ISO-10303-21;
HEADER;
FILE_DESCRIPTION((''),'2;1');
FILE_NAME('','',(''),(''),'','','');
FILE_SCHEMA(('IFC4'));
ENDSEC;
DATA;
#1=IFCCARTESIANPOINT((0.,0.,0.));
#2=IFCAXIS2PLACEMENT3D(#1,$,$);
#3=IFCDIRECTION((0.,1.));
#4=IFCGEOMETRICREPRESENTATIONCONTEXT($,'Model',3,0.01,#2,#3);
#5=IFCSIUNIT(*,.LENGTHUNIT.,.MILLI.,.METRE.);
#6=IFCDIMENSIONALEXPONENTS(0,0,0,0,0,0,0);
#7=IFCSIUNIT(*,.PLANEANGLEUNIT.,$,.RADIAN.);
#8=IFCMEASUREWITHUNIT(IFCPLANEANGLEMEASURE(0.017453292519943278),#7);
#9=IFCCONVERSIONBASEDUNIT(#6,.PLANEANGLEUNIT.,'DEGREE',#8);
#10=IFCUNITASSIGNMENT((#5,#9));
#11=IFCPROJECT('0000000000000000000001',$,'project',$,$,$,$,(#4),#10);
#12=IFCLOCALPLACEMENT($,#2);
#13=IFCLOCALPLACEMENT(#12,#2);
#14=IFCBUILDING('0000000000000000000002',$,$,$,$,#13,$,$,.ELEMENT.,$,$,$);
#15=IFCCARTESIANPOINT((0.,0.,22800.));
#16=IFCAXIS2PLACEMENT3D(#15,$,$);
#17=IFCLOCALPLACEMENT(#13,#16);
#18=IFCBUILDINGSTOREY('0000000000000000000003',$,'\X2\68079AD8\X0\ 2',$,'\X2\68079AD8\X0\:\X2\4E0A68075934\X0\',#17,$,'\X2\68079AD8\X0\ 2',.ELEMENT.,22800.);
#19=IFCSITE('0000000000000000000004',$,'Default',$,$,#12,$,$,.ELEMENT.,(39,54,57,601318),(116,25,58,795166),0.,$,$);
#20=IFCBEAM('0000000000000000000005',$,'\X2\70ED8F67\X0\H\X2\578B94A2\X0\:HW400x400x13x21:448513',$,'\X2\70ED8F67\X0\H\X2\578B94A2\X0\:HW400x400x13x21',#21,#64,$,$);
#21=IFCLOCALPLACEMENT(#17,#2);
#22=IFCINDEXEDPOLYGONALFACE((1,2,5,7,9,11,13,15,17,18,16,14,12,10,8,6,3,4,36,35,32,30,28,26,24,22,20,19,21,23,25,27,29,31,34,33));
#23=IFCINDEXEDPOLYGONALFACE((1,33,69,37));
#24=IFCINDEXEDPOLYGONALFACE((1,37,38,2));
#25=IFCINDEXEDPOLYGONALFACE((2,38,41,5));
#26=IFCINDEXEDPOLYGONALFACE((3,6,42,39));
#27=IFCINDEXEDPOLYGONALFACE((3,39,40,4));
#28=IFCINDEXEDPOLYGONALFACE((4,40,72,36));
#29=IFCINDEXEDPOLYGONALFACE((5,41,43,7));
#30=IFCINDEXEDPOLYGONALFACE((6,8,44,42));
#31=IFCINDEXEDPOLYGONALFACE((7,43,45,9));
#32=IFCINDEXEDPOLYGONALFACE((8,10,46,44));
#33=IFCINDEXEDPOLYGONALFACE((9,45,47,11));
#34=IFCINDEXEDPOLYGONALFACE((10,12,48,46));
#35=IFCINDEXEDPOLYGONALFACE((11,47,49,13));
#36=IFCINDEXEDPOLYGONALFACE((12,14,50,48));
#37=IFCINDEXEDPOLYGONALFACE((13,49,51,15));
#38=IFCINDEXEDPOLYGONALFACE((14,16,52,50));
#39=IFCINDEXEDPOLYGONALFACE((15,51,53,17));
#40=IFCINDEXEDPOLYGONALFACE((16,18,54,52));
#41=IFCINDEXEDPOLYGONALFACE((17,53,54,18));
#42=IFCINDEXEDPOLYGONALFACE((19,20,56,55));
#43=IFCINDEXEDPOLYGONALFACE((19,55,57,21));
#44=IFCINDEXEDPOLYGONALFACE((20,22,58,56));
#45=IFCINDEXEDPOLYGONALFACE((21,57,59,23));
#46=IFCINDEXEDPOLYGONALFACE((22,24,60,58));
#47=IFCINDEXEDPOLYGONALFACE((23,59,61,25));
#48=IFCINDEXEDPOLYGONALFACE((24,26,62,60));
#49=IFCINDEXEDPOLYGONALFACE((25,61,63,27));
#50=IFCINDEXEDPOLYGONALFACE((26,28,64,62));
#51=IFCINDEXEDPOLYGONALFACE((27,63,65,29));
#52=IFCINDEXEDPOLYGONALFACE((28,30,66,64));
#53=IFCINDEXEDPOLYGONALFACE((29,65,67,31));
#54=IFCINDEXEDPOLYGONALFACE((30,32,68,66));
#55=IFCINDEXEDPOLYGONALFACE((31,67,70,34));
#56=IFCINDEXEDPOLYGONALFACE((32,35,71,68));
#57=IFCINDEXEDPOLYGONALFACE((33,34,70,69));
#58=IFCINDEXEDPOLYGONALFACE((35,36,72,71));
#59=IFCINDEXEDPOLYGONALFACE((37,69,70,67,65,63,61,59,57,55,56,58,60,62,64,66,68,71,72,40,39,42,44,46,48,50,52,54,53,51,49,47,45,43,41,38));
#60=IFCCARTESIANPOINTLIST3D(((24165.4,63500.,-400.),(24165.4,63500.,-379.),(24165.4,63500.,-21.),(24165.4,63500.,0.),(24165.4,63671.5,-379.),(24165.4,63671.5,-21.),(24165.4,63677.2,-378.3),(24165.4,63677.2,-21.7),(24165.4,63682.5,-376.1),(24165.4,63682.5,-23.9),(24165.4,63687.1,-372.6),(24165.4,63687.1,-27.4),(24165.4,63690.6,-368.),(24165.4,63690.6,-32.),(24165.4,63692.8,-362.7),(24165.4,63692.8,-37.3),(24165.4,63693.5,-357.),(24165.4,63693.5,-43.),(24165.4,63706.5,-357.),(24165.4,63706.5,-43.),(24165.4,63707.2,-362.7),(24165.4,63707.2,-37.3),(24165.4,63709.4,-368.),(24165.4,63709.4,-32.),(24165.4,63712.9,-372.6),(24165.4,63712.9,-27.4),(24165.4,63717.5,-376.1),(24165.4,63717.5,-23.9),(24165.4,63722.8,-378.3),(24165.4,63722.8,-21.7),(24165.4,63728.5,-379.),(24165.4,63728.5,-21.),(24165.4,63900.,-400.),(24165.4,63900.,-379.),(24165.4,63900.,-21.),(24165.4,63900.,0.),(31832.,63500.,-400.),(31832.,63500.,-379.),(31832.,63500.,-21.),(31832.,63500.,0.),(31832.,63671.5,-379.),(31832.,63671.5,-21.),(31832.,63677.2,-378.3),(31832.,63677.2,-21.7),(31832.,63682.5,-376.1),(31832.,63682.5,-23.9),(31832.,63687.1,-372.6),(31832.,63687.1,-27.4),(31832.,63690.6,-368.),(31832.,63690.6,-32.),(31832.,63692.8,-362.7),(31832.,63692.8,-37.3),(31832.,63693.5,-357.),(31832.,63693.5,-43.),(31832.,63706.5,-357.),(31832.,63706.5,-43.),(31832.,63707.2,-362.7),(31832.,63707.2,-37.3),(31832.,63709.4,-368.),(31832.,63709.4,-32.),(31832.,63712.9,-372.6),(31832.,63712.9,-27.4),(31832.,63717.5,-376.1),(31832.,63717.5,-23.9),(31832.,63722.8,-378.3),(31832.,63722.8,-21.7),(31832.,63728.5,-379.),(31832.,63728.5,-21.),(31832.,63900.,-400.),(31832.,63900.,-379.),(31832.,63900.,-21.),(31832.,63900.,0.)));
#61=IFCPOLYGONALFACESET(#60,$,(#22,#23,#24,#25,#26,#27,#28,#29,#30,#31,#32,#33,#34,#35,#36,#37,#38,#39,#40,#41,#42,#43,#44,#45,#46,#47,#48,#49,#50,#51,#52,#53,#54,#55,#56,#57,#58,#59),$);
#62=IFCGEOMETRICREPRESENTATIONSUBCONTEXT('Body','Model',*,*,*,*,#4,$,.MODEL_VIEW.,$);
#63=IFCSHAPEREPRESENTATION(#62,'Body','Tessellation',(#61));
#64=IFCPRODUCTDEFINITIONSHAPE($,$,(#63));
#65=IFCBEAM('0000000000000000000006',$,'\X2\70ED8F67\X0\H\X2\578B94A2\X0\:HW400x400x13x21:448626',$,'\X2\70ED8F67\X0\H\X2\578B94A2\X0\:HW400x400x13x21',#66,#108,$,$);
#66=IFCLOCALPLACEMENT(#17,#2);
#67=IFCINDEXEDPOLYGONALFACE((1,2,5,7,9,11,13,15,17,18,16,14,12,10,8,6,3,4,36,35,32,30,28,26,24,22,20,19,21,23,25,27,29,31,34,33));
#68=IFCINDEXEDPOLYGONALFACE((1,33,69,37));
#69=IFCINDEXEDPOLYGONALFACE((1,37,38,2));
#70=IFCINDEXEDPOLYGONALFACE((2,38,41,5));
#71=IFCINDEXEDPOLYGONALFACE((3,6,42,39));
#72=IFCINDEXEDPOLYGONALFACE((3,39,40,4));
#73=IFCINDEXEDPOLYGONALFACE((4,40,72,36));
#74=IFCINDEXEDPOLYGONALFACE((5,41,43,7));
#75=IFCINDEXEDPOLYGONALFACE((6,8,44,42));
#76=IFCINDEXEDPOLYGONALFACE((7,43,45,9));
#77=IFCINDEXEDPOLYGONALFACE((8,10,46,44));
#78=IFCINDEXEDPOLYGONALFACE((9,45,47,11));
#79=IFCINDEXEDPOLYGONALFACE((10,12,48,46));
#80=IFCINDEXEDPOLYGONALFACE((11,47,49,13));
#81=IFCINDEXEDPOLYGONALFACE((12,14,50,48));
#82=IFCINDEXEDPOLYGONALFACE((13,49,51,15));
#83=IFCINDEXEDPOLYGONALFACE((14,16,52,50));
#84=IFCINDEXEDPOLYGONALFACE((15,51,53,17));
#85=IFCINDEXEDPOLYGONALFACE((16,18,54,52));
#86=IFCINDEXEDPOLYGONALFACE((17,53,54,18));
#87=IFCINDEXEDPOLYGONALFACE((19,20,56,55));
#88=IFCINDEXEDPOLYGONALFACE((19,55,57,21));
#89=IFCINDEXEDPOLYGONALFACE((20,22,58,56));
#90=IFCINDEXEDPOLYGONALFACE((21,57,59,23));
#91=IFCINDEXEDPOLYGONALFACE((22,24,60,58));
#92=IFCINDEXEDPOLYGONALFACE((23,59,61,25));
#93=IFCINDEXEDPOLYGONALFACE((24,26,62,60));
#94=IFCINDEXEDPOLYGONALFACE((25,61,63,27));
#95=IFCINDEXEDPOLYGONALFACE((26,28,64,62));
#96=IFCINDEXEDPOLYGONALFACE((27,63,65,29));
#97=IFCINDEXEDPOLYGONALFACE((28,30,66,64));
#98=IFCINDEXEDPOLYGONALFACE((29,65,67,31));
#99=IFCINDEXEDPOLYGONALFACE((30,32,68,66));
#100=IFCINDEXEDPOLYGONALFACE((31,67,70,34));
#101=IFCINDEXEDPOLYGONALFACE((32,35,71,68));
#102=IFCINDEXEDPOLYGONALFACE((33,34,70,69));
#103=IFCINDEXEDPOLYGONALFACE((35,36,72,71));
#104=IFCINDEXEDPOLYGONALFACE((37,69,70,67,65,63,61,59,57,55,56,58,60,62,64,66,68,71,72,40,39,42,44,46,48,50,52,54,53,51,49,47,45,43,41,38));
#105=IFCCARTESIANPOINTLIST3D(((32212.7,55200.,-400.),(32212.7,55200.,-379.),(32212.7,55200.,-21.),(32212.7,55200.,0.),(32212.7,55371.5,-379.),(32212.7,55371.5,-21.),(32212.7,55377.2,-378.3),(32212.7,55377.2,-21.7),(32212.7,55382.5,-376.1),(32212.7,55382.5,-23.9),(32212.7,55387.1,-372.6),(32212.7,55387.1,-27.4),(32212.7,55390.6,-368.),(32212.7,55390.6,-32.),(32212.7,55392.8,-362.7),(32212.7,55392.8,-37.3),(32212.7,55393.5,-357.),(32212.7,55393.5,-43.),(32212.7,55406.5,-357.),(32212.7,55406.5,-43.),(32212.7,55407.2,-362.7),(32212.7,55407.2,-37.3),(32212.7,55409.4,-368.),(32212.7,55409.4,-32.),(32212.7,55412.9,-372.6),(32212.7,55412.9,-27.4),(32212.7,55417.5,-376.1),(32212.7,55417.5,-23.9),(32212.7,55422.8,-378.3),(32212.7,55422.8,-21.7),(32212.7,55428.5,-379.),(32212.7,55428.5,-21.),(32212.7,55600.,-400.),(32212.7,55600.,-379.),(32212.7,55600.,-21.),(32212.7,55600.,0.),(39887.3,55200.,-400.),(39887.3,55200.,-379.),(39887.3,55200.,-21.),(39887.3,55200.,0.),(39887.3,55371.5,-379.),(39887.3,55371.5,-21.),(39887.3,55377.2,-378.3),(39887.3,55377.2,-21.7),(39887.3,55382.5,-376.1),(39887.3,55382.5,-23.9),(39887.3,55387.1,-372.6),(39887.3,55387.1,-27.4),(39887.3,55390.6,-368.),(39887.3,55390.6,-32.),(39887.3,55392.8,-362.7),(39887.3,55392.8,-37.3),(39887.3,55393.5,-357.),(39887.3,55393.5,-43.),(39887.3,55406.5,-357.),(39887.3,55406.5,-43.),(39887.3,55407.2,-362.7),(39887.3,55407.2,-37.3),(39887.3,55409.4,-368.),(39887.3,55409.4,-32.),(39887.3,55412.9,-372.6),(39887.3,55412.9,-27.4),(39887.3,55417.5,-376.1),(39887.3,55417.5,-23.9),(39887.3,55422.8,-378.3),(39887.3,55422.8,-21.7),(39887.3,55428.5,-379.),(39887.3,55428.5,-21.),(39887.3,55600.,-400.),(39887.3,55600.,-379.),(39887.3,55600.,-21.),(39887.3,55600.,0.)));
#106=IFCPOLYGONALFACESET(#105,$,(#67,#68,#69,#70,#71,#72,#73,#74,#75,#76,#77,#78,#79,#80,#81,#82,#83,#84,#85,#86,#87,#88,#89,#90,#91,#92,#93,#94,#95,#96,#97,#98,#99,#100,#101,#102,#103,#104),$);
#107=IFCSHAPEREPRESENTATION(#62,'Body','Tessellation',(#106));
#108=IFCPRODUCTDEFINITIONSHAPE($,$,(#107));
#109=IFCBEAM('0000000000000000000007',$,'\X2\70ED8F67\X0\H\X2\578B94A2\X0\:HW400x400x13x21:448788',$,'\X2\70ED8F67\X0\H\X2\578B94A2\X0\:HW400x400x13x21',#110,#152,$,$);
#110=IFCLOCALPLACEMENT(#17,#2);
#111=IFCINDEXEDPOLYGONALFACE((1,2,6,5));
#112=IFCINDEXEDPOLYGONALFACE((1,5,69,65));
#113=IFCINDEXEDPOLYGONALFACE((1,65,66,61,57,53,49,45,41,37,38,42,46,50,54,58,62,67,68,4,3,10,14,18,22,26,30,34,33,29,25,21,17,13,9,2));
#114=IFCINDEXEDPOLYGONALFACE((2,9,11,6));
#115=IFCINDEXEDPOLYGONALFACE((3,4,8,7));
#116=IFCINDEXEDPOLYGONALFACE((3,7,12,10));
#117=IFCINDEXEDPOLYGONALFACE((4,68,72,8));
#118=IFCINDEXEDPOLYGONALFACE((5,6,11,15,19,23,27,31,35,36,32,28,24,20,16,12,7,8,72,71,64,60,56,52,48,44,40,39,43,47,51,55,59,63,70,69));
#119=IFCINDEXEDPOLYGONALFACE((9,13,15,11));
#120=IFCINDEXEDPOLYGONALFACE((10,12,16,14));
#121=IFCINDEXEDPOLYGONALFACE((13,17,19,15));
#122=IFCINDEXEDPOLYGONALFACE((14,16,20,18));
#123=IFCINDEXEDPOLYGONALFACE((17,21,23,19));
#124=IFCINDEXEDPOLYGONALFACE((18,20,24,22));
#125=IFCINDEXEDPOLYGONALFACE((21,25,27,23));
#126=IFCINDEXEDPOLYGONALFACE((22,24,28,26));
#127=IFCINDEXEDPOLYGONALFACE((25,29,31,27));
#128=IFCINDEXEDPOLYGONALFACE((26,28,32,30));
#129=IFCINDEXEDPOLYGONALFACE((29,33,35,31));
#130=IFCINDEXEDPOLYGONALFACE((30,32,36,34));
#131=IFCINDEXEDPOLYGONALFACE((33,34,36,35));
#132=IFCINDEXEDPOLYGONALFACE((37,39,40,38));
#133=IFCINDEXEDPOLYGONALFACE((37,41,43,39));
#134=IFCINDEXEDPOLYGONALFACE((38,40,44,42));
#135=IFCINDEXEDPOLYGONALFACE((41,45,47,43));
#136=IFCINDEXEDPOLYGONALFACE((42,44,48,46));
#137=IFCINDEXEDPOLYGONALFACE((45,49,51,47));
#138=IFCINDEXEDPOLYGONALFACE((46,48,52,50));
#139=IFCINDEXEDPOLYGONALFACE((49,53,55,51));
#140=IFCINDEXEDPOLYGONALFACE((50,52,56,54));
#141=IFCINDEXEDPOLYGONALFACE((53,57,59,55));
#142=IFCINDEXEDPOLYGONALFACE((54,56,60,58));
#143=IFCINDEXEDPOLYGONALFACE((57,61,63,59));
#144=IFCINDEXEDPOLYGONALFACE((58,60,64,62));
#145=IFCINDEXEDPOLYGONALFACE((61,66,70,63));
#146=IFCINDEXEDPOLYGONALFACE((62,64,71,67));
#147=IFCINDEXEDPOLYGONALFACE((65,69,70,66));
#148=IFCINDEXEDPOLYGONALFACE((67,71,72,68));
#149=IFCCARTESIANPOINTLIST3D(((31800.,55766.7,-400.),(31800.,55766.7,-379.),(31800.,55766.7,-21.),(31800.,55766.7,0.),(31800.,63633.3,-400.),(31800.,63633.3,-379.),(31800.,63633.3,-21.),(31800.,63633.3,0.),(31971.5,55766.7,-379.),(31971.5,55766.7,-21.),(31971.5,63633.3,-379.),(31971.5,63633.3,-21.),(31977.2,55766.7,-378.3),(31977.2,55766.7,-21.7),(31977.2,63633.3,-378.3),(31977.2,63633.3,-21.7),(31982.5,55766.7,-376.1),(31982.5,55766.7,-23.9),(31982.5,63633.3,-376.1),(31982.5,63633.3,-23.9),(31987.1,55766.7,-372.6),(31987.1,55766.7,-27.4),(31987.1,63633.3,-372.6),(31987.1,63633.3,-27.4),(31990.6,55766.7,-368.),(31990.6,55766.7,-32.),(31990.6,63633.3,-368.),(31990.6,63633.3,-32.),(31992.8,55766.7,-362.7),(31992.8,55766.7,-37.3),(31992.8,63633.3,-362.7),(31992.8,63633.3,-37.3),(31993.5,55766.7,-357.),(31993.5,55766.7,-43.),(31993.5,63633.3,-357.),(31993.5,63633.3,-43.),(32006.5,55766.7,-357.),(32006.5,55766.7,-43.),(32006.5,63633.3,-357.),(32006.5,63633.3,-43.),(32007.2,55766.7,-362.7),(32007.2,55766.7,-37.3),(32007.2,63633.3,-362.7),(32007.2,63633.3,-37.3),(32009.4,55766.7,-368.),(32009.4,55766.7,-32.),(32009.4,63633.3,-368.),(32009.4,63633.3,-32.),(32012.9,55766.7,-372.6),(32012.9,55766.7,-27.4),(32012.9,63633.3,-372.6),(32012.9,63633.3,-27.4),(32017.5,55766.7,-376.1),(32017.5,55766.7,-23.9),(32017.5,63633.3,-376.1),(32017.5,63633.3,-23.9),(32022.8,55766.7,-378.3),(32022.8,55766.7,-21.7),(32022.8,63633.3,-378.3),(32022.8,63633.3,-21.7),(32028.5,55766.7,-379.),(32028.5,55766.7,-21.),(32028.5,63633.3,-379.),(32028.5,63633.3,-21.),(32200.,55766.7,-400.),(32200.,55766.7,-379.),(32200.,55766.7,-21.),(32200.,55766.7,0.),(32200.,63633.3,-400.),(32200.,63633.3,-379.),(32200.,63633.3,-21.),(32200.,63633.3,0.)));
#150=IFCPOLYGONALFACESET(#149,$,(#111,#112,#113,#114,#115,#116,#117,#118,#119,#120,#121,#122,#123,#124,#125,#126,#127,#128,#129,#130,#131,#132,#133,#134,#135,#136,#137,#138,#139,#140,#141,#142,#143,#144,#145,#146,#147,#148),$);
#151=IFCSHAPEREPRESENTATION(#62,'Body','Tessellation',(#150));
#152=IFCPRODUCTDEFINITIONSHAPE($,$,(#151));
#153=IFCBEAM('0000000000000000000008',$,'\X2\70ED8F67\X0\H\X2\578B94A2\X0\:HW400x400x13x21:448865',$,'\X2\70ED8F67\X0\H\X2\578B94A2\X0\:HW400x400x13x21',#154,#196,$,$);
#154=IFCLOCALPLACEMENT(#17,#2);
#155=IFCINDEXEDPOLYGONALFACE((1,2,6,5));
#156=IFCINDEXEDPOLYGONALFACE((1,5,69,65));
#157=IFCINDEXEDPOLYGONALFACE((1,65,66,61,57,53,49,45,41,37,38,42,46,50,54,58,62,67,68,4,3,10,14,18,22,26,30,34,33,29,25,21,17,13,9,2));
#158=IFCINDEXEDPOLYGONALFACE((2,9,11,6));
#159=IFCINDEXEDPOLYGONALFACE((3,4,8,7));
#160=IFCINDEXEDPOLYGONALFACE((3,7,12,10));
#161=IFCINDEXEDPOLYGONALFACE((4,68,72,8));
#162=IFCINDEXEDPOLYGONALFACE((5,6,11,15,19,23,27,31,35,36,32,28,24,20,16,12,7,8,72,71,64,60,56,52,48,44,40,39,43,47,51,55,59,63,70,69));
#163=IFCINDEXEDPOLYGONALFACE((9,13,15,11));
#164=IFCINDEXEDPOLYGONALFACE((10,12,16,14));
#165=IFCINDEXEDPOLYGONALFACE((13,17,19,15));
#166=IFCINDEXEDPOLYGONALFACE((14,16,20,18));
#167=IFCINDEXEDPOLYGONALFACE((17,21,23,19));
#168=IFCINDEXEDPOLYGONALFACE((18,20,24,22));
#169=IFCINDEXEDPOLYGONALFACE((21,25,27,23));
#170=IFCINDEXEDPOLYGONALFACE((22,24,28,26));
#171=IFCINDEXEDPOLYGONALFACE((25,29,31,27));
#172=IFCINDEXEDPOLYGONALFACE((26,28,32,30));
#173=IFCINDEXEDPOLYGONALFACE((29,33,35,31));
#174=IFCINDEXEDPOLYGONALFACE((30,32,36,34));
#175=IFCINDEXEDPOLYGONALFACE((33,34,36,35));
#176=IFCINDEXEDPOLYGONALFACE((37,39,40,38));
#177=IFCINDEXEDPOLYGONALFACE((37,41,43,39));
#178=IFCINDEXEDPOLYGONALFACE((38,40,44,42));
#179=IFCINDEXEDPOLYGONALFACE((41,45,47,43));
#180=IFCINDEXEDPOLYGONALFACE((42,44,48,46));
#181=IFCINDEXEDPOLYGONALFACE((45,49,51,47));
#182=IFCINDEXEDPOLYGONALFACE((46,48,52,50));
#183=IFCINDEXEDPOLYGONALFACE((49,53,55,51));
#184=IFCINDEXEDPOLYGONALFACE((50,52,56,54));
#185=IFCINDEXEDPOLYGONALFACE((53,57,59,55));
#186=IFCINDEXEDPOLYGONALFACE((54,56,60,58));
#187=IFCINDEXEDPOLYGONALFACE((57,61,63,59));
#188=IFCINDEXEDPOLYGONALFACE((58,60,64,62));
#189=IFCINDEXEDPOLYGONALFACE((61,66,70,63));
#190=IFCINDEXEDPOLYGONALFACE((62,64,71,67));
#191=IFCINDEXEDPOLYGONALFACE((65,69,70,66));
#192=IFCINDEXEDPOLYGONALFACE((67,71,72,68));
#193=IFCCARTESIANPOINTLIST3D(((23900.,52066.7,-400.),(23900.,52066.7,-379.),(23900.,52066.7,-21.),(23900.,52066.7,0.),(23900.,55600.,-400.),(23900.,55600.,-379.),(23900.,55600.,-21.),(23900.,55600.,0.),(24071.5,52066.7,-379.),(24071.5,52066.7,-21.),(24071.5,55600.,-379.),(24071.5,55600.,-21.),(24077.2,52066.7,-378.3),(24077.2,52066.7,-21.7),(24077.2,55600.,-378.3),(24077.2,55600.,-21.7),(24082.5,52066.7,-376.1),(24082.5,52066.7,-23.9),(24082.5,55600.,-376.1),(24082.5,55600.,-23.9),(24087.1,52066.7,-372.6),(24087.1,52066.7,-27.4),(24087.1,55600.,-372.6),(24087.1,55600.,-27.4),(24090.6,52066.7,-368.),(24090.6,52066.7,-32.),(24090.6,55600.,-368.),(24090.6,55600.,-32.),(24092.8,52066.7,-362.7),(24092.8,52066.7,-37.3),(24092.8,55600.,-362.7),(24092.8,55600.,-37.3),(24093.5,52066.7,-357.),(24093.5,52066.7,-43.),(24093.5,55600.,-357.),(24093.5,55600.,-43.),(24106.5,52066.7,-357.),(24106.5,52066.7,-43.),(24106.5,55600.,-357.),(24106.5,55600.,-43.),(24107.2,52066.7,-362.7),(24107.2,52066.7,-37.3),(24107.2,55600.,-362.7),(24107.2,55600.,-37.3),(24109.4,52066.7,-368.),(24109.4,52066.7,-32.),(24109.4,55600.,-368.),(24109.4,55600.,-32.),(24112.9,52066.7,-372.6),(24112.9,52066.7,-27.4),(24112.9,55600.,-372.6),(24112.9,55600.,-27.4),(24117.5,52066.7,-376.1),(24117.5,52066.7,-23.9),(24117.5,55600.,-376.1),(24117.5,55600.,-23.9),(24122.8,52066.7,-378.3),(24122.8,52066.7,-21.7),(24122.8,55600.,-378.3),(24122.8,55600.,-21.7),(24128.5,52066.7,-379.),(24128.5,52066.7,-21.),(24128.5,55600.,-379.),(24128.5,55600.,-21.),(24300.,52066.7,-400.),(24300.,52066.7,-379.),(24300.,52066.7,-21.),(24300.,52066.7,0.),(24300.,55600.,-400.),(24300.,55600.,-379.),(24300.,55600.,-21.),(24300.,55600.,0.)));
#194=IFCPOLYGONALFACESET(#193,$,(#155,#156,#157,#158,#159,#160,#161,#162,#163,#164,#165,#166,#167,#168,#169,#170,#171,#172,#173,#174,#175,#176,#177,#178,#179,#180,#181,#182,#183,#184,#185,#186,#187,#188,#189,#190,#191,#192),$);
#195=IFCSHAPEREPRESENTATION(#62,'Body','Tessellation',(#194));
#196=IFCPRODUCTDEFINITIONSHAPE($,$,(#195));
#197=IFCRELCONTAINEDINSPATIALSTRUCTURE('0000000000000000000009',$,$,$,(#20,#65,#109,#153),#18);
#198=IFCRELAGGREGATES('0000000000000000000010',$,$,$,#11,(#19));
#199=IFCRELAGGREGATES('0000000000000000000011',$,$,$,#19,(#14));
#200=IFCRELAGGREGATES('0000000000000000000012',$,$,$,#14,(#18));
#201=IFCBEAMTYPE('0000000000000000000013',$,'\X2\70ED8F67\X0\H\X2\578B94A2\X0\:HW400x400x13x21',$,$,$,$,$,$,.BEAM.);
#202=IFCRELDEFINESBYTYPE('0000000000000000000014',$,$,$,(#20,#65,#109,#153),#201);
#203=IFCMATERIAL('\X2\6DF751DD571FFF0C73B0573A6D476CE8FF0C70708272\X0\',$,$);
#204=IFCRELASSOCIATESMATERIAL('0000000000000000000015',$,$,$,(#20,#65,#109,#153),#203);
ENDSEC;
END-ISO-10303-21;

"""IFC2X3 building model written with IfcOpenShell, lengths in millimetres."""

from ifc_helpers import new_model, entity, si_unit, converted_unit, direction, frame, frame_2d, origin, place, context, subcontext, project, spatial, i_section, extrude, material, type_object, element, save


model = new_model("IFC2X3")

# Units and contexts
model_context = context("Model", 3, precision=0.01, world=origin(), true_north=direction((0.0, 1.0)))
body_context = subcontext(model_context, "Body", "Model", "MODEL_VIEW")
ifc_project = project(units=[si_unit("LENGTHUNIT", "METRE", prefix="MILLI"), converted_unit("PLANEANGLEUNIT", "DEGREE", entity("IfcPlaneAngleMeasure", 0.017453292519943278), si_unit("PLANEANGLEUNIT", "RADIAN"), dimensions=[0, 0, 0, 0, 0, 0, 0])], contexts=[model_context])

# Site, building, storey
site_placement = place(None, origin())
site = spatial("IfcSite", under=ifc_project, at=site_placement, Name="Default", CompositionType="ELEMENT", RefLatitude=(39, 54, 57, 601318), RefLongitude=(116, 25, 58, 795166), RefElevation=0.0)
building_placement = place(site_placement, origin())
building = spatial("IfcBuilding", under=site, at=building_placement, CompositionType="ELEMENT")
storey_placement = place(building_placement, frame((0.0, 0.0, 22800.0)))
storey = spatial("IfcBuildingStorey", under=building, at=storey_placement, Name="标高 2", ObjectType="标高:上标头", LongName="标高 2", CompositionType="ELEMENT", Elevation=22800.0)

# Beams
ifc_material = material(Name="混凝土，现场浇注，灰色")
beam_type = type_object("IfcBeamType", Name="热轧H型钢:HW400x400x13x21", PredefinedType="BEAM")
beam_1_placement = place(storey_placement, frame((32000.0, 63700.0, 0.0), z_axis=(0.0, 0.0, 1.0), x_axis=(-1.0, 0.0, 0.0)))
element("IfcBeam", 1, at=beam_1_placement, inside=storey, type_object=beam_type, material=ifc_material, Name="热轧H型钢:HW400x400x13x21:448513", ObjectType="热轧H型钢:HW400x400x13x21", context=body_context, shape_type="SweptSolid", body=[
    extrude(i_section(OverallWidth=400.0, OverallDepth=400.0, WebThickness=13.0, FlangeThickness=21.0, FilletRadius=22.0, at=frame_2d((0.0, 0.0), x_axis=(0.0, 1.0))), frame((168.0, 0.0, -200.0), z_axis=(1.0, 0.0, 0.0), x_axis=(0.0, 0.0, -1.0)), (0.0, 0.0, 1.0), 7666.6),
])
beam_2_placement = place(storey_placement, frame((32000.0, 55400.0, 0.0)))
element("IfcBeam", 2, at=beam_2_placement, inside=storey, type_object=beam_type, material=ifc_material, Name="热轧H型钢:HW400x400x13x21:448626", ObjectType="热轧H型钢:HW400x400x13x21", context=body_context, shape_type="SweptSolid", body=[
    extrude(i_section(OverallWidth=400.0, OverallDepth=400.0, WebThickness=13.0, FlangeThickness=21.0, FilletRadius=22.0, at=frame_2d((0.0, 0.0), x_axis=(0.0, 1.0))), frame((212.7, 0.0, -200.0), z_axis=(1.0, 0.0, 0.0), x_axis=(0.0, 0.0, -1.0)), (0.0, 0.0, 1.0), 7674.6),
])
beam_3_placement = place(storey_placement, frame((32000.0, 63700.0, 0.0), z_axis=(0.0, 0.0, 1.0), x_axis=(0.0, -1.0, 0.0)))
element("IfcBeam", 3, at=beam_3_placement, inside=storey, type_object=beam_type, material=ifc_material, Name="热轧H型钢:HW400x400x13x21:448788", ObjectType="热轧H型钢:HW400x400x13x21", context=body_context, shape_type="SweptSolid", body=[
    extrude(i_section(OverallWidth=400.0, OverallDepth=400.0, WebThickness=13.0, FlangeThickness=21.0, FilletRadius=22.0, at=frame_2d((0.0, 0.0), x_axis=(0.0, 1.0))), frame((66.7, 0.0, -200.0), z_axis=(1.0, 0.0, 0.0), x_axis=(0.0, 0.0, -1.0)), (0.0, 0.0, 1.0), 7866.6),
])
beam_4_placement = place(storey_placement, frame((24100.0, 55400.0, 0.0), z_axis=(0.0, 0.0, 1.0), x_axis=(0.0, -1.0, 0.0)))
element("IfcBeam", 4, at=beam_4_placement, inside=storey, type_object=beam_type, material=ifc_material, Name="热轧H型钢:HW400x400x13x21:448865", ObjectType="热轧H型钢:HW400x400x13x21", context=body_context, shape_type="SweptSolid", body=[
    extrude(i_section(OverallWidth=400.0, OverallDepth=400.0, WebThickness=13.0, FlangeThickness=21.0, FilletRadius=22.0, at=frame_2d((0.0, 0.0), x_axis=(0.0, 1.0))), frame((-200.0, 0.0, -200.0), z_axis=(1.0, 0.0, 0.0), x_axis=(0.0, 0.0, -1.0)), (0.0, 0.0, 1.0), 3533.3),
])

save(model, "model.ifc")
